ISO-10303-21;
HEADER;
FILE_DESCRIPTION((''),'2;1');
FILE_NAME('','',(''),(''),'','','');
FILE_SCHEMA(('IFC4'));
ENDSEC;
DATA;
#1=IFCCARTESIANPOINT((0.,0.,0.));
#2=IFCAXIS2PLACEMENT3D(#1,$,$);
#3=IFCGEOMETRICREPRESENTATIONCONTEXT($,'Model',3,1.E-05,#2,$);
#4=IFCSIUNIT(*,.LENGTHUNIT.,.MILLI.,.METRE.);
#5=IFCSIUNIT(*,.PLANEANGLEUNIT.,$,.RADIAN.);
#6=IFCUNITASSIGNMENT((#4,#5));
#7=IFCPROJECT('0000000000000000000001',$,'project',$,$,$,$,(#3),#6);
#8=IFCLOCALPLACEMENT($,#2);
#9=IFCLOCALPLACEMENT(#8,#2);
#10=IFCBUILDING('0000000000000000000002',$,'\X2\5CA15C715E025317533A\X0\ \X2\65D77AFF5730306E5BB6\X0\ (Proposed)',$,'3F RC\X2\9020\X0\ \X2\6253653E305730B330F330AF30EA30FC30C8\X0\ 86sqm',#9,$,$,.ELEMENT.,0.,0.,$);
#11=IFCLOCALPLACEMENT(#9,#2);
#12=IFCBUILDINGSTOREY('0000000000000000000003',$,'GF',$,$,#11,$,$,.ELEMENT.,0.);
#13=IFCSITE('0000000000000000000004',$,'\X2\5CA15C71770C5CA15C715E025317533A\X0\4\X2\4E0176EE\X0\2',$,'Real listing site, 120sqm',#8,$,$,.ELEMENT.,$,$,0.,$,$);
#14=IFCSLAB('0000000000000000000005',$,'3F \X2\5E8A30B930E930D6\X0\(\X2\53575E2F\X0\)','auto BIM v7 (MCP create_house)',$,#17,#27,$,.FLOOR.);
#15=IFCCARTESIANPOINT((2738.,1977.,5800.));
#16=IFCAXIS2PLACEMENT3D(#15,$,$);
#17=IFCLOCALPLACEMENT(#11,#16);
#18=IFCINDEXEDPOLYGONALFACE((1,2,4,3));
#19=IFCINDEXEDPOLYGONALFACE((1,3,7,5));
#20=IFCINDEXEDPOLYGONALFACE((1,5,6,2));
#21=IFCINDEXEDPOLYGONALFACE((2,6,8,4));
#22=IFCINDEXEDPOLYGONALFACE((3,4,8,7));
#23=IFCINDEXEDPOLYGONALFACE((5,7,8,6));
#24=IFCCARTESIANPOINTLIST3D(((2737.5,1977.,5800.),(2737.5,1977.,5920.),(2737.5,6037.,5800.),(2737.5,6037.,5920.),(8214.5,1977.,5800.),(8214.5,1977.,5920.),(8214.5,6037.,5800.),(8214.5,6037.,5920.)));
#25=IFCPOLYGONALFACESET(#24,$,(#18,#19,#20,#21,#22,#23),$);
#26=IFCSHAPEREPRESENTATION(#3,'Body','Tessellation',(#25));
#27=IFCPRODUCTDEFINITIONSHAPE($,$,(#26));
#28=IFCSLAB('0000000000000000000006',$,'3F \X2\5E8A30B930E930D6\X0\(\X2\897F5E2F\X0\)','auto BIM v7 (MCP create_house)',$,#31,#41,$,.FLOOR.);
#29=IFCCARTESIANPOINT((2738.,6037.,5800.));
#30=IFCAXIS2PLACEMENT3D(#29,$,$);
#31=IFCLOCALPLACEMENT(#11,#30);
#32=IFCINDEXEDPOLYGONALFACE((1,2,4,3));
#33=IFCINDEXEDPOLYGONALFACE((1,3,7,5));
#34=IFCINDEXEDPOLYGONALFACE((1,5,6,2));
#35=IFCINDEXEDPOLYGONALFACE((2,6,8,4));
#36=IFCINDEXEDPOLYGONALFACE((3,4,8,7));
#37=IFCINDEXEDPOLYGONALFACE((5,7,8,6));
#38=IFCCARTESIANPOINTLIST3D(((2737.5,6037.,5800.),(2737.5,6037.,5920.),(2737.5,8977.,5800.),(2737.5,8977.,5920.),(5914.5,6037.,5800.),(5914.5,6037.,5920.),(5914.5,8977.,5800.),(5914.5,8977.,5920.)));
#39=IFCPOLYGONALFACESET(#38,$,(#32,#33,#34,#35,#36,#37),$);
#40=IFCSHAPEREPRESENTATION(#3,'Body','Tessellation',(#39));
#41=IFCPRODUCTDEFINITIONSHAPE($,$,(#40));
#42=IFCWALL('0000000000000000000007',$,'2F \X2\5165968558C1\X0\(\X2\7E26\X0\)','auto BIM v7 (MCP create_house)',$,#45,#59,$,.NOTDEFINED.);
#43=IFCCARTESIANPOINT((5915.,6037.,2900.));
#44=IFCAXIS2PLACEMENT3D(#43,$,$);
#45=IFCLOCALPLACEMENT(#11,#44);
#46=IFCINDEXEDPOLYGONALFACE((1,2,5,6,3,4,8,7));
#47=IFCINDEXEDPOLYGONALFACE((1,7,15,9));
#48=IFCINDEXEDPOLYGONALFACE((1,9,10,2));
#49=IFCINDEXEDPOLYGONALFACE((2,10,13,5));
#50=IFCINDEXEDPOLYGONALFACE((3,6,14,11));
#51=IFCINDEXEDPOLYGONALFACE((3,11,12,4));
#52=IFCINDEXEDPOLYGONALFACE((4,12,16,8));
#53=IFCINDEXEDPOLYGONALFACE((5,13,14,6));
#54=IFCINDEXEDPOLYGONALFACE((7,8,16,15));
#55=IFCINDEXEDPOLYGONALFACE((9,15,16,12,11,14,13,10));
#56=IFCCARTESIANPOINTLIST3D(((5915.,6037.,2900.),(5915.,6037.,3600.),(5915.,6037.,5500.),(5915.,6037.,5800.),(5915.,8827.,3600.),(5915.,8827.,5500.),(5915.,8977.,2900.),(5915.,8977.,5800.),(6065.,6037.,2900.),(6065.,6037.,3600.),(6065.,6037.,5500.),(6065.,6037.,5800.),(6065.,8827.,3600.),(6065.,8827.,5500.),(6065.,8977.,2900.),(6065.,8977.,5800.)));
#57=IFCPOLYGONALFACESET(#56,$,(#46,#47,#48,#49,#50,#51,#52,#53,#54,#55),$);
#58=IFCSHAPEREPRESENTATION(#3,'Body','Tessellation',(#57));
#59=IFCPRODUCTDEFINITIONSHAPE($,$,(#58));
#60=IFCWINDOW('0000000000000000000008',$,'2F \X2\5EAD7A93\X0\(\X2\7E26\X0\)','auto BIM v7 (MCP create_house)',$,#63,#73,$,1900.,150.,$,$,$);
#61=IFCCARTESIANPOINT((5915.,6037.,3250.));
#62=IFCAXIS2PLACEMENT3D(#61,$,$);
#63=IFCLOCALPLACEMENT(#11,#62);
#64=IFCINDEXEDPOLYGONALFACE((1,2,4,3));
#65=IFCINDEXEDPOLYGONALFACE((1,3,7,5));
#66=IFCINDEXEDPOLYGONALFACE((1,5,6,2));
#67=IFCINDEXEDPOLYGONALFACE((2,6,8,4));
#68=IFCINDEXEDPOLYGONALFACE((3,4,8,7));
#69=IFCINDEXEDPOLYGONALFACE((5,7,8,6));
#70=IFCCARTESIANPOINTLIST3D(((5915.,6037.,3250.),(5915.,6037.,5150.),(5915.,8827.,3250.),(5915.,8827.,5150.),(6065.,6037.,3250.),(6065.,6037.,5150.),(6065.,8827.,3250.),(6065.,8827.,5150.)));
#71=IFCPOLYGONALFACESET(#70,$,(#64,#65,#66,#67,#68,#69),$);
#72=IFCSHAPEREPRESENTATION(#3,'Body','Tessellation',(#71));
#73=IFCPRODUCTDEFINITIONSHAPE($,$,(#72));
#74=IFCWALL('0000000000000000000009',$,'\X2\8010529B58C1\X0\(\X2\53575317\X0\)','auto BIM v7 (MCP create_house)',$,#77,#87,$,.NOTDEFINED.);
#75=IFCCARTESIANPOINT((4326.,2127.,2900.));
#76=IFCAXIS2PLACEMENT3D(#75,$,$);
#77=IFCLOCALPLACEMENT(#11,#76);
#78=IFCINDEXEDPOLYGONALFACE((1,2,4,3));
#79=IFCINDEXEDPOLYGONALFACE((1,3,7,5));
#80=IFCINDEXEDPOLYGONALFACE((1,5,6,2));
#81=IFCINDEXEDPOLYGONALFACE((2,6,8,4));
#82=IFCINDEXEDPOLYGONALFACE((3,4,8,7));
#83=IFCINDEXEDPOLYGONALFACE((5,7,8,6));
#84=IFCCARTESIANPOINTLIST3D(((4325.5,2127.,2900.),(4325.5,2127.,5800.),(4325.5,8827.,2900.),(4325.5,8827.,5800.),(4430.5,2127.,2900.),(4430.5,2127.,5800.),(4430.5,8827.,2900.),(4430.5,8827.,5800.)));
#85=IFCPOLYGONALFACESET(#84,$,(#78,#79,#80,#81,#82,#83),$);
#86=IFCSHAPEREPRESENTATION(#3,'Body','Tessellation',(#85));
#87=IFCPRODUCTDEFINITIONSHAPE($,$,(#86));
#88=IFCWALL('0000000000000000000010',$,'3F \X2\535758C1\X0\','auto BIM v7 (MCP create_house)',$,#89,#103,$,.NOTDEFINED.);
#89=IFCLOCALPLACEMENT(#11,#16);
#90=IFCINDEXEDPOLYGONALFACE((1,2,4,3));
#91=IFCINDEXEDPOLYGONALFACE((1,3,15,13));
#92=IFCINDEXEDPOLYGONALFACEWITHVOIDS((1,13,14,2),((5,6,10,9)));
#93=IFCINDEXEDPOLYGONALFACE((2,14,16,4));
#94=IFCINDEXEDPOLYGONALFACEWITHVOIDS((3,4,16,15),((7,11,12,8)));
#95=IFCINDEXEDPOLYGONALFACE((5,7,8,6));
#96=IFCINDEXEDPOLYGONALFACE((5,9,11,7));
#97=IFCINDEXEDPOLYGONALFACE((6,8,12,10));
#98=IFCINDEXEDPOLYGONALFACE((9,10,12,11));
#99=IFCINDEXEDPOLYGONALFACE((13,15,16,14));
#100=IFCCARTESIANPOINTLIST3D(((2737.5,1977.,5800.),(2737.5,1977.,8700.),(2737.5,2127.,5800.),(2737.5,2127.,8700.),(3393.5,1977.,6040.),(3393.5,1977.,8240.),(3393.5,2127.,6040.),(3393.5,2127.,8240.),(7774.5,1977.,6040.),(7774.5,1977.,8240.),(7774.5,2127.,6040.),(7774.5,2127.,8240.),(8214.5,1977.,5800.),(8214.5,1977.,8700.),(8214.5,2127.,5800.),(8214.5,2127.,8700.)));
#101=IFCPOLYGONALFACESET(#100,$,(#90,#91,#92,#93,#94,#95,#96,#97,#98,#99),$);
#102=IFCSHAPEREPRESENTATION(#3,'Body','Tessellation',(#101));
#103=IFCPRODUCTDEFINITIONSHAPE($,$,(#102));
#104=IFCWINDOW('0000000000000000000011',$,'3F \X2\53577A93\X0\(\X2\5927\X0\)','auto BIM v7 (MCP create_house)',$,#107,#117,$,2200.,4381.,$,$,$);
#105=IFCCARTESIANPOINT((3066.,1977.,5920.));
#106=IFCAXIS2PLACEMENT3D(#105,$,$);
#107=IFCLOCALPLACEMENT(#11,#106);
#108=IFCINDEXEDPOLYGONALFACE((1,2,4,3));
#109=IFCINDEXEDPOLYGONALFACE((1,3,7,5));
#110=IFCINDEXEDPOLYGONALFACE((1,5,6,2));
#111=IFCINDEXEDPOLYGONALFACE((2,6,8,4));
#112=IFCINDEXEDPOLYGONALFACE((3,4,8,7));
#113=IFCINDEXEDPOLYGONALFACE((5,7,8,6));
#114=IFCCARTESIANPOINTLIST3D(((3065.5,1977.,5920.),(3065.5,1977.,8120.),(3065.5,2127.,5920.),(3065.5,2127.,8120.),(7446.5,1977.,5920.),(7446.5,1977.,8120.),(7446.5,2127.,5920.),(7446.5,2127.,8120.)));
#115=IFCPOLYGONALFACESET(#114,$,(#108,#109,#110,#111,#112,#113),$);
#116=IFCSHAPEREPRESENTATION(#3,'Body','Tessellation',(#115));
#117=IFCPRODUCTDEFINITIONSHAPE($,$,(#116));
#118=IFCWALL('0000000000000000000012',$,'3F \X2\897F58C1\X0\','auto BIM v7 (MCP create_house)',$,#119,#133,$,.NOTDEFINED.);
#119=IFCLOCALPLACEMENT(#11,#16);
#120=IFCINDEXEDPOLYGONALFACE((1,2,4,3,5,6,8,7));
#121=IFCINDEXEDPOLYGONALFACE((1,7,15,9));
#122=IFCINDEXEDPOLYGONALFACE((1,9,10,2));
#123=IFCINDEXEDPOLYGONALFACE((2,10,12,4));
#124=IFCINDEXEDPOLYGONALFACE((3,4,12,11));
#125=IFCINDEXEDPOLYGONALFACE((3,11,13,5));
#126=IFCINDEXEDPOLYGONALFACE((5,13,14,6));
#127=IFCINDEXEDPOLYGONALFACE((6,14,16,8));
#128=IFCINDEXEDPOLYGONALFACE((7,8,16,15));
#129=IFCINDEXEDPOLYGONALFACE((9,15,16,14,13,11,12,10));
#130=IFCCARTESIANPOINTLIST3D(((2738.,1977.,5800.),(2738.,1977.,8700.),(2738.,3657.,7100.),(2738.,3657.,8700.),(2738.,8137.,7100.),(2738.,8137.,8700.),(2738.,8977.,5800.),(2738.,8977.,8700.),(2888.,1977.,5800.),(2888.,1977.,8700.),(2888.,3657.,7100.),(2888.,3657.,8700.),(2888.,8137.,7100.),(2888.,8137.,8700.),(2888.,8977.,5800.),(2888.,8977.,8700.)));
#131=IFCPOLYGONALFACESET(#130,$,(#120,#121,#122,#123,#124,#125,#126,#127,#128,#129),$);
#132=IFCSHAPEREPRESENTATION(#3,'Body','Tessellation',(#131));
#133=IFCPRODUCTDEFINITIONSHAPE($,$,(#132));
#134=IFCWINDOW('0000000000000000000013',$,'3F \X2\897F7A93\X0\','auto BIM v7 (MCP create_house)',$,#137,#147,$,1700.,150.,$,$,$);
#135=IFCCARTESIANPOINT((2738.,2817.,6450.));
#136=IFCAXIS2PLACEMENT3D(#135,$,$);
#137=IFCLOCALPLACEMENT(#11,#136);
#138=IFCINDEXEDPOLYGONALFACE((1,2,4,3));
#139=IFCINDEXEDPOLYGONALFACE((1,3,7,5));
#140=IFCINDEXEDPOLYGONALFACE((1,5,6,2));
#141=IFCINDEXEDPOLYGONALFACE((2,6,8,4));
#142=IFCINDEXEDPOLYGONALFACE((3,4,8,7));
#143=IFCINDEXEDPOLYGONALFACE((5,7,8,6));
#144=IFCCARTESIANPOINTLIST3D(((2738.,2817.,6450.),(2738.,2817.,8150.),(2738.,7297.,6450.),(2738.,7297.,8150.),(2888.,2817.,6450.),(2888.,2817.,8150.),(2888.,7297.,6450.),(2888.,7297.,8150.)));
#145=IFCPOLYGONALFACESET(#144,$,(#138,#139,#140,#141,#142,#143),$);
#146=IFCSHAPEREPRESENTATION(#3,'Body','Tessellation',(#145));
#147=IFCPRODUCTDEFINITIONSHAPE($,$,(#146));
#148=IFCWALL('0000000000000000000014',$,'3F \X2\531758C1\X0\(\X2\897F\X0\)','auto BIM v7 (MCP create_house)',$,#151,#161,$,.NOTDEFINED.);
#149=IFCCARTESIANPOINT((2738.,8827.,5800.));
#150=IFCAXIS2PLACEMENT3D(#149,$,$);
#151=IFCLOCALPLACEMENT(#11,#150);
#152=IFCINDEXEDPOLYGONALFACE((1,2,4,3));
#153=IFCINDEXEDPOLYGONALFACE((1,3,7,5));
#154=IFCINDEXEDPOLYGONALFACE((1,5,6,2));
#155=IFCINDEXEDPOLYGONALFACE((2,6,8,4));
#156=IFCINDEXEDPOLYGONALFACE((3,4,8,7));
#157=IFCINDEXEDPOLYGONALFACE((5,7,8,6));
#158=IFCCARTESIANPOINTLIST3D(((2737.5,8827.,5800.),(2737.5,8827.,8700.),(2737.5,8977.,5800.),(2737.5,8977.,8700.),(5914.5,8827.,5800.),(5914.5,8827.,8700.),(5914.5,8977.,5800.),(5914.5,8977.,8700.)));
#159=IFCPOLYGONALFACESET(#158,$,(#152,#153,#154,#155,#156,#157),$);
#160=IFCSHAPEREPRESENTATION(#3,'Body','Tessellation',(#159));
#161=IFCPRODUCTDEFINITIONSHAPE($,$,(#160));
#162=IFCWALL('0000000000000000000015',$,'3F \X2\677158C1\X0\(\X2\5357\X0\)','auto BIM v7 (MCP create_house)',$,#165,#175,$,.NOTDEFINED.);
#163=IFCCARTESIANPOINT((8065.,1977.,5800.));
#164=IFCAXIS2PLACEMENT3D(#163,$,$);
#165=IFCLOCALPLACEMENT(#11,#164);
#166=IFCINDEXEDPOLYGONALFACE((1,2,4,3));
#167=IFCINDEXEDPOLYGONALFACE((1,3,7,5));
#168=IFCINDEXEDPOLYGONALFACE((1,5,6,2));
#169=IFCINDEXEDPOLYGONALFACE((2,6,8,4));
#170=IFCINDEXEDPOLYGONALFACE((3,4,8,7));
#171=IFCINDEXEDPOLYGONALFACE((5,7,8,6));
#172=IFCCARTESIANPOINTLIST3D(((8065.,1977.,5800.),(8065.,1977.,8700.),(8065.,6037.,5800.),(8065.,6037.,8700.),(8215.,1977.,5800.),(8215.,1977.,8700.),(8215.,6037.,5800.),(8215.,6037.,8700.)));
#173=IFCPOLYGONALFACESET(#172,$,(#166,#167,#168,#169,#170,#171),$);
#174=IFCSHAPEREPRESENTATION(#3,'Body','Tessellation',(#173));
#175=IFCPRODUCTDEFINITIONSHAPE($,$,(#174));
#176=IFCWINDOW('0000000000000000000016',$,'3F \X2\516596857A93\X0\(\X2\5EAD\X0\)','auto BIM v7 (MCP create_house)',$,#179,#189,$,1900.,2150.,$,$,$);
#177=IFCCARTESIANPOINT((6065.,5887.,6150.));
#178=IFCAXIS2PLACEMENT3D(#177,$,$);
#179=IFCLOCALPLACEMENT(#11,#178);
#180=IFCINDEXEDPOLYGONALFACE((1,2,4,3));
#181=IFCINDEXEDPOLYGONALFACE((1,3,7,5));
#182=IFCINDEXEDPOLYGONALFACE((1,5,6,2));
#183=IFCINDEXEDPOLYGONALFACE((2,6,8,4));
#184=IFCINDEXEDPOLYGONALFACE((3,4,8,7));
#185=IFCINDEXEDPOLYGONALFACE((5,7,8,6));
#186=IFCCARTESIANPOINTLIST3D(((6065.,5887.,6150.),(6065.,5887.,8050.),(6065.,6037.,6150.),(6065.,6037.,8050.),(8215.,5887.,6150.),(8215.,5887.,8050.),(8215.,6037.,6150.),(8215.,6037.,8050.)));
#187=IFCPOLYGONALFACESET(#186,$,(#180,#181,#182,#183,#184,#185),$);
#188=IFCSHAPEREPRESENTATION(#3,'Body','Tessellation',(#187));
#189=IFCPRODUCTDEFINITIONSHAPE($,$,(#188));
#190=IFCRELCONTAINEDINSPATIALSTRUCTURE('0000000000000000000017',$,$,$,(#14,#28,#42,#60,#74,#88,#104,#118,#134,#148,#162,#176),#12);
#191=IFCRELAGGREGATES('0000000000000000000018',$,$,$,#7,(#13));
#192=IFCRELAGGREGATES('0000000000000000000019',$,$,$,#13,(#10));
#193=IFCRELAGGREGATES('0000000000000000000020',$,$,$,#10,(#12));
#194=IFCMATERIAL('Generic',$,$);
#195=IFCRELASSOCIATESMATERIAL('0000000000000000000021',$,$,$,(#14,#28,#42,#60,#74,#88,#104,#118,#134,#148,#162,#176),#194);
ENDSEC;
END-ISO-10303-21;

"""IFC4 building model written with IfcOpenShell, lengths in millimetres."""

from ifc_helpers import new_model, si_unit, frame, frame_2d, origin, place, context, project, spatial, rectangle, extrude, material, element, fill, save


model = new_model("IFC4")

# Units and contexts
model_context = context("Model", 3, precision=1e-05, world=origin())
ifc_project = project(units=[si_unit("LENGTHUNIT", "METRE", prefix="MILLI"), si_unit("PLANEANGLEUNIT", "RADIAN")], contexts=[model_context])

# Site, building, storey
site_placement = place(None, origin())
site = spatial("IfcSite", under=ifc_project, at=site_placement, Name="岡山県岡山市北区4丁目2", ObjectType="Real listing site, 120sqm", CompositionType="ELEMENT", RefElevation=0.0)
building_placement = place(site_placement, origin())
building = spatial("IfcBuilding", under=site, at=building_placement, Name="岡山市北区 旗竿地の家 (Proposed)", ObjectType="3F RC造 打放しコンクリート 86sqm", CompositionType="ELEMENT", ElevationOfRefHeight=0.0, ElevationOfTerrain=0.0)
storey_placement = place(building_placement, origin())
storey = spatial("IfcBuildingStorey", under=building, at=storey_placement, Name="GF", CompositionType="ELEMENT", Elevation=0.0)

# Slabs
ifc_material = material(Name="Generic")
slab_1_placement = place(storey_placement, frame((2738.0, 1977.0, 5800.0)))
element("IfcSlab", 1, at=slab_1_placement, inside=storey, material=ifc_material, Name="3F 床スラブ(南帯)", Description="auto BIM v7 (MCP create_house)", PredefinedType="FLOOR", context=model_context, shape_type="SweptSolid", body=[
    extrude(rectangle(XDim=5477.0, YDim=4060.0, at=frame_2d((2738.0, 2030.0))), frame((2738.0, 1977.0, 5800.0)), (0.0, 0.0, 1.0), 120.0),
])
slab_2_placement = place(storey_placement, frame((2738.0, 6037.0, 5800.0)))
element("IfcSlab", 2, at=slab_2_placement, inside=storey, material=ifc_material, Name="3F 床スラブ(西帯)", Description="auto BIM v7 (MCP create_house)", PredefinedType="FLOOR", context=model_context, shape_type="SweptSolid", body=[
    extrude(rectangle(XDim=3177.0, YDim=2940.0, at=frame_2d((1588.0, 1470.0))), frame((2738.0, 6037.0, 5800.0)), (0.0, 0.0, 1.0), 120.0),
])

# Wall, opening, window
wall_1_placement = place(storey_placement, frame((5915.0, 6037.0, 2900.0)))
wall_1 = element("IfcWall", 3, at=wall_1_placement, inside=storey, material=ifc_material, Name="2F 入隅壁(縦)", Description="auto BIM v7 (MCP create_house)", PredefinedType="NOTDEFINED", context=model_context, shape_type="SweptSolid", body=[
    extrude(rectangle(XDim=150.0, YDim=2940.0, at=frame_2d((75.0, 1470.0))), frame((5915.0, 6037.0, 2900.0)), (0.0, 0.0, 1.0), 2900.0),
])
opening_1_placement = place(storey_placement, frame((5915.0, 6037.0, 3250.0)))
opening_1 = element("IfcOpeningElement", 4, at=opening_1_placement, cuts=wall_1, PredefinedType="NOTDEFINED", context=model_context, shape_type="SweptSolid", body=[
    extrude(rectangle(XDim=150.0, YDim=2790.0, at=frame_2d((75.0, 1395.0))), frame((5915.0, 6037.0, 3250.0)), (0.0, 0.0, 1.0), 1900.0),
])
window_1_placement = place(storey_placement, frame((5915.0, 6037.0, 3250.0)))
window_1 = element("IfcWindow", 5, at=window_1_placement, inside=storey, material=ifc_material, Name="2F 庭窓(縦)", Description="auto BIM v7 (MCP create_house)", OverallHeight=1900.0, OverallWidth=150.0, context=model_context, shape_type="SweptSolid", body=[
    extrude(rectangle(XDim=150.0, YDim=2790.0, at=frame_2d((75.0, 1395.0))), frame((5915.0, 6037.0, 3250.0)), (0.0, 0.0, 1.0), 1900.0),
])
fill(opening_1, window_1)

# Wall
wall_2_placement = place(storey_placement, frame((4326.0, 2127.0, 2900.0)))
element("IfcWall", 6, at=wall_2_placement, inside=storey, material=ifc_material, Name="耐力壁(南北)", Description="auto BIM v7 (MCP create_house)", PredefinedType="NOTDEFINED", context=model_context, shape_type="SweptSolid", body=[
    extrude(rectangle(XDim=105.0, YDim=6700.0, at=frame_2d((52.0, 3350.0))), frame((4326.0, 2127.0, 2900.0)), (0.0, 0.0, 1.0), 2900.0),
])

# Walls, openings, windows
wall_3_placement = place(storey_placement, frame((2738.0, 1977.0, 5800.0)))
wall_3 = element("IfcWall", 7, at=wall_3_placement, inside=storey, material=ifc_material, Name="3F 南壁", Description="auto BIM v7 (MCP create_house)", PredefinedType="NOTDEFINED", context=model_context, shape_type="SweptSolid", body=[
    extrude(rectangle(XDim=5477.0, YDim=150.0, at=frame_2d((2738.0, 75.0))), frame((2738.0, 1977.0, 5800.0)), (0.0, 0.0, 1.0), 2900.0),
])
opening_2_placement = place(storey_placement, frame((3066.0, 1977.0, 5920.0)))
opening_2 = element("IfcOpeningElement", 8, at=opening_2_placement, cuts=wall_3, PredefinedType="NOTDEFINED", context=model_context, shape_type="SweptSolid", body=[
    extrude(rectangle(XDim=4381.0, YDim=150.0, at=frame_2d((2190.0, 75.0))), frame((3066.0, 1977.0, 5920.0)), (0.0, 0.0, 1.0), 2200.0),
])
window_2_placement = place(storey_placement, frame((3066.0, 1977.0, 5920.0)))
window_2 = element("IfcWindow", 9, at=window_2_placement, inside=storey, material=ifc_material, Name="3F 南窓(大)", Description="auto BIM v7 (MCP create_house)", OverallHeight=2200.0, OverallWidth=4381.0, context=model_context, shape_type="SweptSolid", body=[
    extrude(rectangle(XDim=4381.0, YDim=150.0, at=frame_2d((2190.0, 75.0))), frame((3066.0, 1977.0, 5920.0)), (0.0, 0.0, 1.0), 2200.0),
])
fill(opening_2, window_2)
wall_4_placement = place(storey_placement, frame((2738.0, 1977.0, 5800.0)))
wall_4 = element("IfcWall", 10, at=wall_4_placement, inside=storey, material=ifc_material, Name="3F 西壁", Description="auto BIM v7 (MCP create_house)", PredefinedType="NOTDEFINED", context=model_context, shape_type="SweptSolid", body=[
    extrude(rectangle(XDim=150.0, YDim=7000.0, at=frame_2d((75.0, 3500.0))), frame((2738.0, 1977.0, 5800.0)), (0.0, 0.0, 1.0), 2900.0),
])
opening_3_placement = place(storey_placement, frame((2738.0, 2817.0, 6450.0)))
opening_3 = element("IfcOpeningElement", 11, at=opening_3_placement, cuts=wall_4, PredefinedType="NOTDEFINED", context=model_context, shape_type="SweptSolid", body=[
    extrude(rectangle(XDim=150.0, YDim=4480.0, at=frame_2d((75.0, 2240.0))), frame((2738.0, 2817.0, 6450.0)), (0.0, 0.0, 1.0), 1700.0),
])
window_3_placement = place(storey_placement, frame((2738.0, 2817.0, 6450.0)))
window_3 = element("IfcWindow", 12, at=window_3_placement, inside=storey, material=ifc_material, Name="3F 西窓", Description="auto BIM v7 (MCP create_house)", OverallHeight=1700.0, OverallWidth=150.0, context=model_context, shape_type="SweptSolid", body=[
    extrude(rectangle(XDim=150.0, YDim=4480.0, at=frame_2d((75.0, 2240.0))), frame((2738.0, 2817.0, 6450.0)), (0.0, 0.0, 1.0), 1700.0),
])
fill(opening_3, window_3)

# Wall
wall_5_placement = place(storey_placement, frame((2738.0, 8827.0, 5800.0)))
element("IfcWall", 13, at=wall_5_placement, inside=storey, material=ifc_material, Name="3F 北壁(西)", Description="auto BIM v7 (MCP create_house)", PredefinedType="NOTDEFINED", context=model_context, shape_type="SweptSolid", body=[
    extrude(rectangle(XDim=3177.0, YDim=150.0, at=frame_2d((1588.0, 75.0))), frame((2738.0, 8827.0, 5800.0)), (0.0, 0.0, 1.0), 2900.0),
])

# Wall, opening, window
wall_6_placement = place(storey_placement, frame((8065.0, 1977.0, 5800.0)))
wall_6 = element("IfcWall", 14, at=wall_6_placement, inside=storey, material=ifc_material, Name="3F 東壁(南)", Description="auto BIM v7 (MCP create_house)", PredefinedType="NOTDEFINED", context=model_context, shape_type="SweptSolid", body=[
    extrude(rectangle(XDim=150.0, YDim=4060.0, at=frame_2d((75.0, 2030.0))), frame((8065.0, 1977.0, 5800.0)), (0.0, 0.0, 1.0), 2900.0),
])
opening_4_placement = place(storey_placement, frame((6065.0, 5887.0, 6150.0)))
opening_4 = element("IfcOpeningElement", 15, at=opening_4_placement, cuts=wall_6, PredefinedType="NOTDEFINED", context=model_context, shape_type="SweptSolid", body=[
    extrude(rectangle(XDim=2150.0, YDim=150.0, at=frame_2d((1075.0, 75.0))), frame((6065.0, 5887.0, 6150.0)), (0.0, 0.0, 1.0), 1900.0),
])
window_4_placement = place(storey_placement, frame((6065.0, 5887.0, 6150.0)))
window_4 = element("IfcWindow", 16, at=window_4_placement, inside=storey, material=ifc_material, Name="3F 入隅窓(庭)", Description="auto BIM v7 (MCP create_house)", OverallHeight=1900.0, OverallWidth=2150.0, context=model_context, shape_type="SweptSolid", body=[
    extrude(rectangle(XDim=2150.0, YDim=150.0, at=frame_2d((1075.0, 75.0))), frame((6065.0, 5887.0, 6150.0)), (0.0, 0.0, 1.0), 1900.0),
])
fill(opening_4, window_4)

save(model, "model.ifc")
